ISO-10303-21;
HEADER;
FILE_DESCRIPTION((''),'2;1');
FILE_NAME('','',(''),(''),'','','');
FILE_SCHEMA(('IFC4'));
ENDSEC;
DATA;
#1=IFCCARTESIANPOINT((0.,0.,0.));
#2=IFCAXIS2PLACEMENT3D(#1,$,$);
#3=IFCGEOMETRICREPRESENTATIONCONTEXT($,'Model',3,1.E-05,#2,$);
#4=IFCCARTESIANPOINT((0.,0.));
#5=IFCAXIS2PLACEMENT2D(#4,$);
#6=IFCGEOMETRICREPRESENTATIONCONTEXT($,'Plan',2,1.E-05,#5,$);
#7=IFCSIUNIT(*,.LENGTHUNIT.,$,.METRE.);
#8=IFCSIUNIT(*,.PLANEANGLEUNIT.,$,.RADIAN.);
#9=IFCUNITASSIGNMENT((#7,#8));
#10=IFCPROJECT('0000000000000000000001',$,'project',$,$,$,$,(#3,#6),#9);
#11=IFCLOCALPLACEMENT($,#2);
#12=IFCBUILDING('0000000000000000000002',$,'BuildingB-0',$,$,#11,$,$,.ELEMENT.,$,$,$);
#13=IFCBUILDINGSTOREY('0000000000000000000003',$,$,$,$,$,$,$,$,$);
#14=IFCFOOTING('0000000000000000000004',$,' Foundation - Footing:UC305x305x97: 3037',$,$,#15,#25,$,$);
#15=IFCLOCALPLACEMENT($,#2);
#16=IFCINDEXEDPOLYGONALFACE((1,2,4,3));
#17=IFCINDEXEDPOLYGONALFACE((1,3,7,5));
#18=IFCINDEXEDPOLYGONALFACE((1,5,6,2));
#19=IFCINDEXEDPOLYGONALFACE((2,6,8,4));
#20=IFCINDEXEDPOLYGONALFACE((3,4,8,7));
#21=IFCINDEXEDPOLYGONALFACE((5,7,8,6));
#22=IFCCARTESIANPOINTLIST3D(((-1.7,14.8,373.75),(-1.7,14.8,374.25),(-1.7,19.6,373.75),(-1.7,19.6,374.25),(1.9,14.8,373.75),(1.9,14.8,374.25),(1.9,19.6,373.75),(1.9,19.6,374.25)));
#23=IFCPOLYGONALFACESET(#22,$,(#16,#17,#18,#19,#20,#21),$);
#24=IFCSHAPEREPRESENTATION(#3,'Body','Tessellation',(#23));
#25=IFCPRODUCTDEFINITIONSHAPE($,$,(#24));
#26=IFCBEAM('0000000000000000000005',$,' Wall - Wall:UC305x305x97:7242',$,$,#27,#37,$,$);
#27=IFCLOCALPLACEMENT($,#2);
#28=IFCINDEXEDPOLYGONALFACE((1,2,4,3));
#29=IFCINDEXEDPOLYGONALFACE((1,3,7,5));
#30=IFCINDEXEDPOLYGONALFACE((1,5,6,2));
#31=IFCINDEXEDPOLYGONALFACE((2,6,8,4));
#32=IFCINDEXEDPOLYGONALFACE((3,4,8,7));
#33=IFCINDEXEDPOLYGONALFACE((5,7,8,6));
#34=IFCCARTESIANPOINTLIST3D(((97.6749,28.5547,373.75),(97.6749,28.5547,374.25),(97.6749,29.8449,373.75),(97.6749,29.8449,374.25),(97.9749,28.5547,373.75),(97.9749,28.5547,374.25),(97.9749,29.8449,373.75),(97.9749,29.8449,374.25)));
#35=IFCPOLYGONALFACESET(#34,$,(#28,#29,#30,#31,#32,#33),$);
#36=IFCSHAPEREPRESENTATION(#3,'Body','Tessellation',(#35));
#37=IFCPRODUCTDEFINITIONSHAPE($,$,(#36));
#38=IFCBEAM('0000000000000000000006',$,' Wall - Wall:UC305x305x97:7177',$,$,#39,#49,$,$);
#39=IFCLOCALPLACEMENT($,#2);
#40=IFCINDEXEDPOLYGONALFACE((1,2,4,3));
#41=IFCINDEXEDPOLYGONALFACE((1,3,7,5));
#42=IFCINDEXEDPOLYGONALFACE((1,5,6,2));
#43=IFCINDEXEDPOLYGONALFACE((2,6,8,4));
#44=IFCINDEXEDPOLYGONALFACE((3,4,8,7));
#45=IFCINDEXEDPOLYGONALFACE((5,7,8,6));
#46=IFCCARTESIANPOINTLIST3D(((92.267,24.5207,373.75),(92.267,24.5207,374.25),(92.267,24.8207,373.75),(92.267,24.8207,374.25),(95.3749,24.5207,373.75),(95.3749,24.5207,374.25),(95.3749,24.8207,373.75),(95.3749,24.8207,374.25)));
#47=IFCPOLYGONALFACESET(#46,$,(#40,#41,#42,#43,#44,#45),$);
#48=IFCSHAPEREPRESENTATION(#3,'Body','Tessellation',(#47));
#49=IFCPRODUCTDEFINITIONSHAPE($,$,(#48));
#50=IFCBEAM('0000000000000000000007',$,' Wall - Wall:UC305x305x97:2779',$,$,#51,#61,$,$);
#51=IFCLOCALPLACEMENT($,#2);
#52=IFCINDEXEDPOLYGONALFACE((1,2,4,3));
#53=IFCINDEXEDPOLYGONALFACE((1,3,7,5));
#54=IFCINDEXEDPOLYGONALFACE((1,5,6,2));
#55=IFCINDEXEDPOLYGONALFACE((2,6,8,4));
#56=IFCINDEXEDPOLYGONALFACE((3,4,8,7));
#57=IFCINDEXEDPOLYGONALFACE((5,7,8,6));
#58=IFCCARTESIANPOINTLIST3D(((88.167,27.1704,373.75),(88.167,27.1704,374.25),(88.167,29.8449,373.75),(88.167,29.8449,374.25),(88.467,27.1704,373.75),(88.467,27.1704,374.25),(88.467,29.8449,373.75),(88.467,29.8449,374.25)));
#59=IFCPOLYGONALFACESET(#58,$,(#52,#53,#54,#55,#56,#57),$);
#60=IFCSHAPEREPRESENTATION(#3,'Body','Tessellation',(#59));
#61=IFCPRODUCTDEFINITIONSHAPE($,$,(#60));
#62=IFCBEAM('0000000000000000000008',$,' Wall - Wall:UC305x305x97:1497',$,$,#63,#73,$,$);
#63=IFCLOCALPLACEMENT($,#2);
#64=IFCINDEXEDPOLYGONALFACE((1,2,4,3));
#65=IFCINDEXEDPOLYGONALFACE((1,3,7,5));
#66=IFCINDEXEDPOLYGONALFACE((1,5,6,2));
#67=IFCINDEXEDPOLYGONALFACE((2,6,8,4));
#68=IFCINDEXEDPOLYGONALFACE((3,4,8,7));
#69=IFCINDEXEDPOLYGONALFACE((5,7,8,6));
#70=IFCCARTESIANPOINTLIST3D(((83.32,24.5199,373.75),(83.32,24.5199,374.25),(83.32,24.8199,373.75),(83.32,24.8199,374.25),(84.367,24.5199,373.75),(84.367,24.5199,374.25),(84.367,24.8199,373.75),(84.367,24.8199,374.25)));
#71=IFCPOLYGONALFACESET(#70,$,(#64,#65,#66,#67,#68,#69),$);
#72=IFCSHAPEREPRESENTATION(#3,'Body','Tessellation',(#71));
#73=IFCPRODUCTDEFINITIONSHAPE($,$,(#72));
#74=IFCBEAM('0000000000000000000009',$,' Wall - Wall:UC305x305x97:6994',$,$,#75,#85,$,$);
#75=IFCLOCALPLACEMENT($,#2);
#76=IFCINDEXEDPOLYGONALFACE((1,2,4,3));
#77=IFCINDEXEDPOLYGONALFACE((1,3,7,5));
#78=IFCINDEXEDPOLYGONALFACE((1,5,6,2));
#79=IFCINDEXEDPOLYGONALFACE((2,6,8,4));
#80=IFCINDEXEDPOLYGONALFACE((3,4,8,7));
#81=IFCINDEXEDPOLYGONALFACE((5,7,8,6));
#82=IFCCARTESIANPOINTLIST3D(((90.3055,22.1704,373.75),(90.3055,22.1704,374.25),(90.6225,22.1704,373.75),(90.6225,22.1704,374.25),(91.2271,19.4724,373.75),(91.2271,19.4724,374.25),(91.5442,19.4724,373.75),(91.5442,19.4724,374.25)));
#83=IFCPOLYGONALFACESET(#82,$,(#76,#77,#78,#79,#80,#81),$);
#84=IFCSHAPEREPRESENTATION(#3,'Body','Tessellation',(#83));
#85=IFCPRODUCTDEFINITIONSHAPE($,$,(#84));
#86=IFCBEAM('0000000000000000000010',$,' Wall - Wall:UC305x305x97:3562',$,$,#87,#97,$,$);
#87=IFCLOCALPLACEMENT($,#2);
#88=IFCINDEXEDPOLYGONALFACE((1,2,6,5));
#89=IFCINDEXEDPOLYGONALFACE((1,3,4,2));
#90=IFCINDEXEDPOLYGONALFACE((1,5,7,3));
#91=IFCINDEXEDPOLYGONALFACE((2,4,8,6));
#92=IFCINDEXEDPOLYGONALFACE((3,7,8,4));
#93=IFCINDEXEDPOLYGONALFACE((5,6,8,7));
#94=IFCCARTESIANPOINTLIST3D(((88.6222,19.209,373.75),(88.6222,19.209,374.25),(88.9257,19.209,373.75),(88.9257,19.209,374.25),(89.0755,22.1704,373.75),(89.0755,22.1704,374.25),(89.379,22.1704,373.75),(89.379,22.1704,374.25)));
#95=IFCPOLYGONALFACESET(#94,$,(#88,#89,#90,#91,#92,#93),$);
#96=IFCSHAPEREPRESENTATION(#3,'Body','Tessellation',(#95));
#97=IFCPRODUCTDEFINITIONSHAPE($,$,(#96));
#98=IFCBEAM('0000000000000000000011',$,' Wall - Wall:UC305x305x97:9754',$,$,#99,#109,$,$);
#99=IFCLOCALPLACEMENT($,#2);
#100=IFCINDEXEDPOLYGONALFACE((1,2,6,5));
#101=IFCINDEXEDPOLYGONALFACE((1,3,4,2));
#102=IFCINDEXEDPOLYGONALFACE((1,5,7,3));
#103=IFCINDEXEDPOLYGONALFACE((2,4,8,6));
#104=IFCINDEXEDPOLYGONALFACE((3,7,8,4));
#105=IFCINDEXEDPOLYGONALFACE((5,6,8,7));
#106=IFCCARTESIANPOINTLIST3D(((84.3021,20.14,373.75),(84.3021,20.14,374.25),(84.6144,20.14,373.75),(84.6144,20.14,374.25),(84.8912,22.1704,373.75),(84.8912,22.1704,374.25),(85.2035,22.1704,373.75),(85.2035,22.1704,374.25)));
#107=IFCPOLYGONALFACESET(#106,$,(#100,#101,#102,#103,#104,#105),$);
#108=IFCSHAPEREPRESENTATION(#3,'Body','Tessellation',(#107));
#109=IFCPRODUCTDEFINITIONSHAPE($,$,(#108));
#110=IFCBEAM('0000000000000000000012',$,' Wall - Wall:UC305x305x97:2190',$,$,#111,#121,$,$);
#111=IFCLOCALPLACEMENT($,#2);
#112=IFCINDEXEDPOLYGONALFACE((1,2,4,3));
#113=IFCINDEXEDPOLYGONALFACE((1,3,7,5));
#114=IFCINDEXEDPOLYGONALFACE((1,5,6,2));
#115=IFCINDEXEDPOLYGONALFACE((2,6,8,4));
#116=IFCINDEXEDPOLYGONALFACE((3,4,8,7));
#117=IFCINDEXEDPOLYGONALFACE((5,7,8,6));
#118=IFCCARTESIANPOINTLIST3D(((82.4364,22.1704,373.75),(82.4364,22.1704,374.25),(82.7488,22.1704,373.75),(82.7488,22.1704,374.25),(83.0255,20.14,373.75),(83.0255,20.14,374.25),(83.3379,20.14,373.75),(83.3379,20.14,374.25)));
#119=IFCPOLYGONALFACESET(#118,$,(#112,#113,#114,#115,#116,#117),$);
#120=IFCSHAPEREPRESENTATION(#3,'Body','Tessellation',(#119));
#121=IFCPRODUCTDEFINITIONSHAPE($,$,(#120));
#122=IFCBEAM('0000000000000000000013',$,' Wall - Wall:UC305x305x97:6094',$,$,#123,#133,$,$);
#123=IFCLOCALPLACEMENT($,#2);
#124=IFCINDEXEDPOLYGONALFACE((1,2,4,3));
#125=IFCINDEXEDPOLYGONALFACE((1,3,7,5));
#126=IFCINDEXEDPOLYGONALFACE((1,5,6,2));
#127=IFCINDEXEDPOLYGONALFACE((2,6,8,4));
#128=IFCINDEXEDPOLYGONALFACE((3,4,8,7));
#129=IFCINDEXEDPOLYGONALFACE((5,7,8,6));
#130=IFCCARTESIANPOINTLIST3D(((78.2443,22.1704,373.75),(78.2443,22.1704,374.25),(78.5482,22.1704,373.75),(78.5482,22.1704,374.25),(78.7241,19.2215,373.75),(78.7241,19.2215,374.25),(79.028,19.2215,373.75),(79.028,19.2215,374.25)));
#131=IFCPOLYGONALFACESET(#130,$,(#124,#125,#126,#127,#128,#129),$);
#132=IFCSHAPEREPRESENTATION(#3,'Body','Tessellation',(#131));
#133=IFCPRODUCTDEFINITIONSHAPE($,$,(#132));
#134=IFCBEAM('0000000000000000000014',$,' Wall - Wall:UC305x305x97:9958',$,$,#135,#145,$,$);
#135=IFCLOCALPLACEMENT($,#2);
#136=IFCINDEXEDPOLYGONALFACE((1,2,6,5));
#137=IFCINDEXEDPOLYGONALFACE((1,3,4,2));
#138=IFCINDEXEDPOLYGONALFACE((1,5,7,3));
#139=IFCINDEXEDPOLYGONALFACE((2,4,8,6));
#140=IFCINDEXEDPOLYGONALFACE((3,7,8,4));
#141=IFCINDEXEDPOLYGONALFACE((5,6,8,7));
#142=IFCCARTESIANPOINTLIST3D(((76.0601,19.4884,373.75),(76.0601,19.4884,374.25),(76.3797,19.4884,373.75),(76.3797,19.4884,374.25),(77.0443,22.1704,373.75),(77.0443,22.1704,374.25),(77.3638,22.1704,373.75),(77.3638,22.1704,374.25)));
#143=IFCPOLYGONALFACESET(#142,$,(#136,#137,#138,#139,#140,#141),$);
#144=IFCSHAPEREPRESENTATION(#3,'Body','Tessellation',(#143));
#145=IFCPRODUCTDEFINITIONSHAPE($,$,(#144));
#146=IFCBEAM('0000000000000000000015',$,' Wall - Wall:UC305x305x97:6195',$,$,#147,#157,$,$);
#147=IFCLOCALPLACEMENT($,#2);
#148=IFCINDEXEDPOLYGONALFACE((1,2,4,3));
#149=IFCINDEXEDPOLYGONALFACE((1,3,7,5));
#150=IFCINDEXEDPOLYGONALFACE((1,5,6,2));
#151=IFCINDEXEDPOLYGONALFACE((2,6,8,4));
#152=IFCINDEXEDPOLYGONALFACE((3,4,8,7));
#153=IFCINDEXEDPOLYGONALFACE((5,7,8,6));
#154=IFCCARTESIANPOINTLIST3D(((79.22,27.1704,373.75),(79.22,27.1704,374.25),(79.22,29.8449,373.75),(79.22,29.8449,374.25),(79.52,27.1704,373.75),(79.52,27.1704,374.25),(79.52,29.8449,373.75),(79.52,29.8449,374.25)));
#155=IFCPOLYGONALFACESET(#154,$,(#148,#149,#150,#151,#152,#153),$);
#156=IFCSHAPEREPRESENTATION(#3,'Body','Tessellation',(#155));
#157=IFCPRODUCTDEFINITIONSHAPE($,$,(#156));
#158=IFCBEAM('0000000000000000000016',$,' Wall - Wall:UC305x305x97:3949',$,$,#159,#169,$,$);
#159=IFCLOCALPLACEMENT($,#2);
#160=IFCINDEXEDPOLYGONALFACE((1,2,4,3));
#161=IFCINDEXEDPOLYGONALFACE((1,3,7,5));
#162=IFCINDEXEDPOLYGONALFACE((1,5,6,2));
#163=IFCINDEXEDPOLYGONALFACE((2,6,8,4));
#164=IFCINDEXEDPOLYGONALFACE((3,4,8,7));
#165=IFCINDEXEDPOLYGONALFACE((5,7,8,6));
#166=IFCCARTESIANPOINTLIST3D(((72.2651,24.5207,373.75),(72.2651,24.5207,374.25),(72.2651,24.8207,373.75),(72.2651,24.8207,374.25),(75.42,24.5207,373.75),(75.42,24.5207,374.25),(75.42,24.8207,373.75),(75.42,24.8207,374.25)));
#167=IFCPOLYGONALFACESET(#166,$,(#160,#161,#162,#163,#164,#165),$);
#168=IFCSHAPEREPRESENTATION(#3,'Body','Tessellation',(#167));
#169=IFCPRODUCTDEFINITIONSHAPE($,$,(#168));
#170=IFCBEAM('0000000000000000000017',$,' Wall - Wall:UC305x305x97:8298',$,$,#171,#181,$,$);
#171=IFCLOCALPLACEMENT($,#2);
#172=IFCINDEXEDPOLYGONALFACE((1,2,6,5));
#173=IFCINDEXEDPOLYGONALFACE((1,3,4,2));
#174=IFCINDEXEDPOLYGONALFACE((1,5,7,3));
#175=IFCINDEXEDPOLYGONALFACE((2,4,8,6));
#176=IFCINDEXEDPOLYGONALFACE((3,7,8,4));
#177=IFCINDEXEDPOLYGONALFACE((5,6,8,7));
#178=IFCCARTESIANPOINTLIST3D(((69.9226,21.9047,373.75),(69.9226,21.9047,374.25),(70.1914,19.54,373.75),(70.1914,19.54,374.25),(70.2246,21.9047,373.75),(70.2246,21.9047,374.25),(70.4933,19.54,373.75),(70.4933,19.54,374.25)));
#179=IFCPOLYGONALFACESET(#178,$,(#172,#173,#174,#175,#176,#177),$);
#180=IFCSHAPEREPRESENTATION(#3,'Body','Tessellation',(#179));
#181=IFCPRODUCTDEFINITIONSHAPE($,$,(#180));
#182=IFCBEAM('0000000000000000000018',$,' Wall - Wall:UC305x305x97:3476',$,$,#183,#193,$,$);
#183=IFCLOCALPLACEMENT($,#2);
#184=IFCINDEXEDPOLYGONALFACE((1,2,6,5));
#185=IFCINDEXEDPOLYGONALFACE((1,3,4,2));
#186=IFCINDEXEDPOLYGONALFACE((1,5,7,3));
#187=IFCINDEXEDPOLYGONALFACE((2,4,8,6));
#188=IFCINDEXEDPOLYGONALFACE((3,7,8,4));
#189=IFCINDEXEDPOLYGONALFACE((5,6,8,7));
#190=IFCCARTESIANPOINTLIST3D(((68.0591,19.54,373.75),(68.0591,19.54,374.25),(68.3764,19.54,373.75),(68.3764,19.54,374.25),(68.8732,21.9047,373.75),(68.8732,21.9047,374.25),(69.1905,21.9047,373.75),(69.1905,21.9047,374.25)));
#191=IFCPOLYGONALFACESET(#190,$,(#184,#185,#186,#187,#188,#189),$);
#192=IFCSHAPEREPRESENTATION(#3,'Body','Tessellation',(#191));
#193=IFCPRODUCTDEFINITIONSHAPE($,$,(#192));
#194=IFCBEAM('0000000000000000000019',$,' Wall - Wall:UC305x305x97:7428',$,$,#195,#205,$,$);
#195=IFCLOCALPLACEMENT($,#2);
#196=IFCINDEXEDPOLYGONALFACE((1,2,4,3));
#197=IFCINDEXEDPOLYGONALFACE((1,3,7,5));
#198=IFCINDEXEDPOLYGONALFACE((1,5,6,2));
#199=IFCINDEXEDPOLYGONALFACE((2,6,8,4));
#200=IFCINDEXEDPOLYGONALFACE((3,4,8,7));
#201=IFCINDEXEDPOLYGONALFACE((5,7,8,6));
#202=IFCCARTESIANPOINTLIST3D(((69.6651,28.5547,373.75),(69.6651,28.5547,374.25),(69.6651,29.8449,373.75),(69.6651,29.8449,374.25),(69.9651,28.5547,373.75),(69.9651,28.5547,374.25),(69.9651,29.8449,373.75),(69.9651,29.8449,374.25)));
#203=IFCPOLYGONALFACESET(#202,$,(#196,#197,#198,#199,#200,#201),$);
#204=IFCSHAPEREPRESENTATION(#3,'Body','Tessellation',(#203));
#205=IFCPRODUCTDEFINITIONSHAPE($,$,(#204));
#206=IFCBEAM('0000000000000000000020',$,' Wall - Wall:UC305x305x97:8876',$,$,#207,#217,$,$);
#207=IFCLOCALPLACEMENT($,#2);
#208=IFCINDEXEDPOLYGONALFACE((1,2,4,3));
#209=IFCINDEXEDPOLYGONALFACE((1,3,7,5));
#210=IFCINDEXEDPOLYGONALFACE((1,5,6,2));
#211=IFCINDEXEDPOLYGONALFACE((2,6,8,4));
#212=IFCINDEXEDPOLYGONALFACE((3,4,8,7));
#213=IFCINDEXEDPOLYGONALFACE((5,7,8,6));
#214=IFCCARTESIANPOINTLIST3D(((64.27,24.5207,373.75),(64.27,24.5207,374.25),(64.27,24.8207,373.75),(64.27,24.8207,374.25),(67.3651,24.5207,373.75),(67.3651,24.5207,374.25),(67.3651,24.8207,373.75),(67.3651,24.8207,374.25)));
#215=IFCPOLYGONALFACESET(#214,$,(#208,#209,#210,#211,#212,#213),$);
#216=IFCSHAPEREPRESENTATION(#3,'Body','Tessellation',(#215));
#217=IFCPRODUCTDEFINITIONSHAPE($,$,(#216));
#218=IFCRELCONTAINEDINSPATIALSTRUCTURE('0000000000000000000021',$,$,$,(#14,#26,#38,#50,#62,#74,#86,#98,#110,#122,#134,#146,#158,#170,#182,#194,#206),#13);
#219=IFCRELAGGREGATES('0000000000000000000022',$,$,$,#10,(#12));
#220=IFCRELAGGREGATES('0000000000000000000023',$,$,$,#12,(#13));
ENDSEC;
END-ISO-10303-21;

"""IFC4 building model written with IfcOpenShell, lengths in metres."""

from ifc_helpers import new_model, si_unit, origin, origin_2d, place, context, project, spatial, polyline, outline, extrude, element, save


model = new_model("IFC4")

# Units and contexts
model_context = context("Model", 3, precision=1e-05, world=origin())
plan_context = context("Plan", 2, precision=1e-05, world=origin_2d())
ifc_project = project(units=[si_unit("LENGTHUNIT", "METRE"), si_unit("PLANEANGLEUNIT", "RADIAN")], contexts=[model_context, plan_context])

# Building, storey
building_placement = place(None, origin())
building = spatial("IfcBuilding", under=ifc_project, at=building_placement, Name="BuildingB-0", CompositionType="ELEMENT")
storey = spatial("IfcBuildingStorey", under=building)

# Footing
element("IfcFooting", 1, inside=storey, Name=" Foundation - Footing:UC305x305x97: 3037", context=model_context, shape_type="SweptSolid", body=[
    extrude(outline(polyline([(1.9, 19.6, 373.75), (-1.7, 19.6, 373.75), (-1.7, 14.8, 373.75), (1.9, 14.8, 373.75), (1.9, 19.6, 373.75)])), None, (0.0, 0.0, 1.0), 0.5),
])

# Beams
element("IfcBeam", 2, inside=storey, Name=" Wall - Wall:UC305x305x97:7242", context=model_context, shape_type="SweptSolid", body=[
    extrude(outline(polyline([(97.9749, 28.5547, 373.75), (97.6749, 28.5547, 373.75), (97.6749, 29.8449, 373.75), (97.9749, 29.8449, 373.75), (97.9749, 28.5547, 373.75)])), None, (0.0, 0.0, 1.0), 0.5),
])
element("IfcBeam", 3, inside=storey, Name=" Wall - Wall:UC305x305x97:7177", context=model_context, shape_type="SweptSolid", body=[
    extrude(outline(polyline([(95.3749, 24.5207, 373.75), (95.3749, 24.8207, 373.75), (92.267, 24.8207, 373.75), (92.267, 24.5207, 373.75), (95.3749, 24.5207, 373.75)])), None, (0.0, 0.0, 1.0), 0.5),
])
element("IfcBeam", 4, inside=storey, Name=" Wall - Wall:UC305x305x97:2779", context=model_context, shape_type="SweptSolid", body=[
    extrude(outline(polyline([(88.467, 27.1704, 373.75), (88.167, 27.1704, 373.75), (88.167, 29.8449, 373.75), (88.467, 29.8449, 373.75), (88.467, 27.1704, 373.75)])), None, (0.0, 0.0, 1.0), 0.5),
])
element("IfcBeam", 5, inside=storey, Name=" Wall - Wall:UC305x305x97:1497", context=model_context, shape_type="SweptSolid", body=[
    extrude(outline(polyline([(84.367, 24.5199, 373.75), (84.367, 24.8199, 373.75), (83.32, 24.8199, 373.75), (83.32, 24.5199, 373.75), (84.367, 24.5199, 373.75)])), None, (0.0, 0.0, 1.0), 0.5),
])
element("IfcBeam", 6, inside=storey, Name=" Wall - Wall:UC305x305x97:6994", context=model_context, shape_type="SweptSolid", body=[
    extrude(outline(polyline([(91.5442, 19.4724, 373.75), (91.2271, 19.4724, 373.75), (90.3055, 22.1704, 373.75), (90.6225, 22.1704, 373.75), (91.5442, 19.4724, 373.75)])), None, (0.0, 0.0, 1.0), 0.5),
])
element("IfcBeam", 7, inside=storey, Name=" Wall - Wall:UC305x305x97:3562", context=model_context, shape_type="SweptSolid", body=[
    extrude(outline(polyline([(88.9257, 19.209, 373.75), (88.6222, 19.209, 373.75), (89.0755, 22.1704, 373.75), (89.379, 22.1704, 373.75), (88.9257, 19.209, 373.75)])), None, (0.0, 0.0, 1.0), 0.5),
])
element("IfcBeam", 8, inside=storey, Name=" Wall - Wall:UC305x305x97:9754", context=model_context, shape_type="SweptSolid", body=[
    extrude(outline(polyline([(84.6144, 20.14, 373.75), (84.3021, 20.14, 373.75), (84.8912, 22.1704, 373.75), (85.2035, 22.1704, 373.75), (84.6144, 20.14, 373.75)])), None, (0.0, 0.0, 1.0), 0.5),
])
element("IfcBeam", 9, inside=storey, Name=" Wall - Wall:UC305x305x97:2190", context=model_context, shape_type="SweptSolid", body=[
    extrude(outline(polyline([(83.3379, 20.14, 373.75), (82.7488, 22.1704, 373.75), (82.4364, 22.1704, 373.75), (83.0255, 20.14, 373.75), (83.3379, 20.14, 373.75)])), None, (0.0, 0.0, 1.0), 0.5),
])
element("IfcBeam", 10, inside=storey, Name=" Wall - Wall:UC305x305x97:6094", context=model_context, shape_type="SweptSolid", body=[
    extrude(outline(polyline([(79.028, 19.2215, 373.75), (78.7241, 19.2215, 373.75), (78.2443, 22.1704, 373.75), (78.5482, 22.1704, 373.75), (79.028, 19.2215, 373.75)])), None, (0.0, 0.0, 1.0), 0.5),
])
element("IfcBeam", 11, inside=storey, Name=" Wall - Wall:UC305x305x97:9958", context=model_context, shape_type="SweptSolid", body=[
    extrude(outline(polyline([(76.3797, 19.4884, 373.75), (76.0601, 19.4884, 373.75), (77.0443, 22.1704, 373.75), (77.3638, 22.1704, 373.75), (76.3797, 19.4884, 373.75)])), None, (0.0, 0.0, 1.0), 0.5),
])
element("IfcBeam", 12, inside=storey, Name=" Wall - Wall:UC305x305x97:6195", context=model_context, shape_type="SweptSolid", body=[
    extrude(outline(polyline([(79.52, 27.1704, 373.75), (79.22, 27.1704, 373.75), (79.22, 29.8449, 373.75), (79.52, 29.8449, 373.75), (79.52, 27.1704, 373.75)])), None, (0.0, 0.0, 1.0), 0.5),
])
element("IfcBeam", 13, inside=storey, Name=" Wall - Wall:UC305x305x97:3949", context=model_context, shape_type="SweptSolid", body=[
    extrude(outline(polyline([(75.42, 24.5207, 373.75), (75.42, 24.8207, 373.75), (72.2651, 24.8207, 373.75), (72.2651, 24.5207, 373.75), (75.42, 24.5207, 373.75)])), None, (0.0, 0.0, 1.0), 0.5),
])
element("IfcBeam", 14, inside=storey, Name=" Wall - Wall:UC305x305x97:8298", context=model_context, shape_type="SweptSolid", body=[
    extrude(outline(polyline([(70.4933, 19.54, 373.75), (70.1914, 19.54, 373.75), (69.9226, 21.9047, 373.75), (70.2246, 21.9047, 373.75), (70.4933, 19.54, 373.75)])), None, (0.0, 0.0, 1.0), 0.5),
])
element("IfcBeam", 15, inside=storey, Name=" Wall - Wall:UC305x305x97:3476", context=model_context, shape_type="SweptSolid", body=[
    extrude(outline(polyline([(68.3764, 19.54, 373.75), (68.0591, 19.54, 373.75), (68.8732, 21.9047, 373.75), (69.1905, 21.9047, 373.75), (68.3764, 19.54, 373.75)])), None, (0.0, 0.0, 1.0), 0.5),
])
element("IfcBeam", 16, inside=storey, Name=" Wall - Wall:UC305x305x97:7428", context=model_context, shape_type="SweptSolid", body=[
    extrude(outline(polyline([(69.9651, 28.5547, 373.75), (69.6651, 28.5547, 373.75), (69.6651, 29.8449, 373.75), (69.9651, 29.8449, 373.75), (69.9651, 28.5547, 373.75)])), None, (0.0, 0.0, 1.0), 0.5),
])
element("IfcBeam", 17, inside=storey, Name=" Wall - Wall:UC305x305x97:8876", context=model_context, shape_type="SweptSolid", body=[
    extrude(outline(polyline([(67.3651, 24.5207, 373.75), (67.3651, 24.8207, 373.75), (64.27, 24.8207, 373.75), (64.27, 24.5207, 373.75), (67.3651, 24.5207, 373.75)])), None, (0.0, 0.0, 1.0), 0.5),
])

save(model, "model.ifc")
